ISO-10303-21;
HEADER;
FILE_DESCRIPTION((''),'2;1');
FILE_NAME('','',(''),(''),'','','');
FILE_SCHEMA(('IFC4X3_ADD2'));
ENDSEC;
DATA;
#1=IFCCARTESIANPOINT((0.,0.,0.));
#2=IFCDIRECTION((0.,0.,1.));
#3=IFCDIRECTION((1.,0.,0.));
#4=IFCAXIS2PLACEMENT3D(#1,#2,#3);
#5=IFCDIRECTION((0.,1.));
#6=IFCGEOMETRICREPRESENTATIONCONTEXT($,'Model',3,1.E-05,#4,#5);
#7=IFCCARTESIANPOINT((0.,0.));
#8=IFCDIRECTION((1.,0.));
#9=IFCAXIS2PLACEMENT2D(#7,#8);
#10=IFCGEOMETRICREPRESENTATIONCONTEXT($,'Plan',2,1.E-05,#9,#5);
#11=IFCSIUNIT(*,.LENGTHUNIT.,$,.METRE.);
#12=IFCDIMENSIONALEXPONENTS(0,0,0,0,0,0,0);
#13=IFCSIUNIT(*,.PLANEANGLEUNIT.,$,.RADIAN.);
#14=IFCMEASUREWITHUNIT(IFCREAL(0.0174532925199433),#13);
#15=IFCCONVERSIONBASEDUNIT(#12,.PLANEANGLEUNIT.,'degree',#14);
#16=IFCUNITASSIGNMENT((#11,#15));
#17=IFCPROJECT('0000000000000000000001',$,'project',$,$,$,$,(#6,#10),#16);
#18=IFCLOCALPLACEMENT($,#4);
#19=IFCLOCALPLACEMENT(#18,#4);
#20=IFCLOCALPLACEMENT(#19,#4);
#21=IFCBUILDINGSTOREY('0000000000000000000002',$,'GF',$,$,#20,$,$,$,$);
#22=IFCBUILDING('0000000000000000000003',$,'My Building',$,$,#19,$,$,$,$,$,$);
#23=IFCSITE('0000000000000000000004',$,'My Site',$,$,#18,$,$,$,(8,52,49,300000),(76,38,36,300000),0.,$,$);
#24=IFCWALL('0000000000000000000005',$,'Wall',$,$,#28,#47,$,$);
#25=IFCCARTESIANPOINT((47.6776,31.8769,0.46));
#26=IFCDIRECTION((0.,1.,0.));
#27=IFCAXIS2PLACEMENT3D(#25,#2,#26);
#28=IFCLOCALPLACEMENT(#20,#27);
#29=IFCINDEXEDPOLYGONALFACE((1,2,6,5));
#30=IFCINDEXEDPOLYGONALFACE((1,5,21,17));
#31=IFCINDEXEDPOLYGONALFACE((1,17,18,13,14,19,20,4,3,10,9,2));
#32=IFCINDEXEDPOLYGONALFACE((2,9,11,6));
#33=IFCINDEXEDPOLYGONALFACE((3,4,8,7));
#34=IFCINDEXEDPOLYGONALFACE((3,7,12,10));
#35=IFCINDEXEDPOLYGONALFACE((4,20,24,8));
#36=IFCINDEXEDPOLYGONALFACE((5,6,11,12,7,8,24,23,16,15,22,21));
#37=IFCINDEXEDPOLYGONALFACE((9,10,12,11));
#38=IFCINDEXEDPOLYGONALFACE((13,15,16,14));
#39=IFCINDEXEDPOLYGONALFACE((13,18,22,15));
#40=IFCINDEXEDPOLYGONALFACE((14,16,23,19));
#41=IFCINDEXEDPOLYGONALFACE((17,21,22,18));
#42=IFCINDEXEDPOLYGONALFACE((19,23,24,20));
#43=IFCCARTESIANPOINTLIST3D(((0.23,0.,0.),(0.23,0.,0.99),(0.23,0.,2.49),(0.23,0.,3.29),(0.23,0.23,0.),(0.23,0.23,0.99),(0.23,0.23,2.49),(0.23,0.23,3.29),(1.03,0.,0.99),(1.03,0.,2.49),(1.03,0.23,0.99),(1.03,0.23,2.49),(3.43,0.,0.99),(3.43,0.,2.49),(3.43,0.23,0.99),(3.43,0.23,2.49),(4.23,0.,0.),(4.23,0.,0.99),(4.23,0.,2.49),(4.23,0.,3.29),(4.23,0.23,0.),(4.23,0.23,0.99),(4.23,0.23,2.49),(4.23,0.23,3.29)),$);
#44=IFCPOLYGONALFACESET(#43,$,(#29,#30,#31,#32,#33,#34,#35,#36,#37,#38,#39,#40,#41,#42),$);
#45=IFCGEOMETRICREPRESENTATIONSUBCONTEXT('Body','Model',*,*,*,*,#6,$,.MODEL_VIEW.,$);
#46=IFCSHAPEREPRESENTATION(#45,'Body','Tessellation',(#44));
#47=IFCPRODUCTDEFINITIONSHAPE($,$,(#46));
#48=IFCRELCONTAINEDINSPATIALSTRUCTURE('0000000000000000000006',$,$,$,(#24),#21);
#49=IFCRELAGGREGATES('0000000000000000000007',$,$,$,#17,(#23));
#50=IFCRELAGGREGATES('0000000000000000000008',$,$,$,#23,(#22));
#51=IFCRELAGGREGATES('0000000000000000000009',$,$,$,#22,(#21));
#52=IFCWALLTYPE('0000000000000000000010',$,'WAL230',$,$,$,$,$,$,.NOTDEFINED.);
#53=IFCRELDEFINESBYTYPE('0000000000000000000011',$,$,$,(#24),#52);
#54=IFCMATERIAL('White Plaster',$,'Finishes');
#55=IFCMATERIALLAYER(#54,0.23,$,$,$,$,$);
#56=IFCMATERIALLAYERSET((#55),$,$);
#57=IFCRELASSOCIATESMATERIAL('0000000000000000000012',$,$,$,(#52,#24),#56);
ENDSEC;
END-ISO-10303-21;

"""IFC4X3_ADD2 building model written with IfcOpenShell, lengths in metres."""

from ifc_helpers import new_model, entity, si_unit, converted_unit, direction, frame, origin_with_axes, origin_2d_with_axis, place, context, subcontext, project, spatial, line, indexed_curve, outline, extrude, source, transform, mapped, material, layer, layer_set, layer_usage, type_object, element, save


model = new_model("IFC4X3_ADD2")

# Units and contexts
model_context = context("Model", 3, precision=1e-05, world=origin_with_axes(), true_north=direction((0.0, 1.0)))
plan_context = context("Plan", 2, precision=1e-05, world=origin_2d_with_axis(), true_north=direction((0.0, 1.0)))
body_context_1 = subcontext(model_context, "Body", "Model", "MODEL_VIEW")
ifc_project = project(units=[si_unit("LENGTHUNIT", "METRE"), converted_unit("PLANEANGLEUNIT", "degree", entity("IfcReal", 0.0174532925199433), si_unit("PLANEANGLEUNIT", "RADIAN"), dimensions=[0, 0, 0, 0, 0, 0, 0])], contexts=[model_context, plan_context])

# Site, building, storey
site_placement = place(None, origin_with_axes())
site = spatial("IfcSite", under=ifc_project, at=site_placement, Name="My Site", RefLatitude=(8, 52, 49, 300000), RefLongitude=(76, 38, 36, 300000), RefElevation=0.0)
building_placement = place(site_placement, origin_with_axes())
building = spatial("IfcBuilding", under=site, at=building_placement, Name="My Building")
storey_placement = place(building_placement, origin_with_axes())
storey = spatial("IfcBuildingStorey", under=building, at=storey_placement, Name="GF")

# Wall, openings
ifc_material_1 = material(Name="White Plaster", Category="Finishes")
ifc_layer_1 = layer(ifc_material_1, 0.23)
ifc_layer_set_1 = layer_set([ifc_layer_1])
ifc_layer_usage_1 = layer_usage(ifc_layer_set_1, "AXIS2", "POSITIVE", 0.0)
wall_type = type_object("IfcWallType", Name="WAL230", PredefinedType="NOTDEFINED", material=ifc_layer_set_1)
wall_1_placement = place(storey_placement, frame((47.6776, 31.8769, 0.46), z_axis=(0.0, 0.0, 1.0), x_axis=(0.0, 1.0, 0.0)))
wall_1 = element("IfcWall", 1, at=wall_1_placement, inside=storey, type_object=wall_type, material=ifc_layer_usage_1, Name="Wall", context=body_context_1, shape_type="SweptSolid", body=[
    extrude(outline(indexed_curve([(0.23, 0.0), (0.23, 0.23), (4.23, 0.23), (4.23, 0.0)], segments=[line(1, 2, 3, 4, 1)])), origin_with_axes(), (0.0, 0.0, 1.0), 3.29),
])
shared_shape_1 = source(origin_with_axes(), body_context_1, "Body", "SweptSolid", [
    extrude(outline(indexed_curve([(0.0, 0.0), (0.8, 0.0), (0.8, 1.5), (0.0, 1.5)], segments=[line(1, 2, 3, 4, 1)])), frame((0.0, -0.6, 0.0), z_axis=(0.0, -1.0, 0.0), x_axis=(1.0, 0.0, 0.0)), (0.0, 0.0, -1.0), 1.2),
])
opening_1_placement = place(wall_1_placement, frame((1.03, 0.23, 0.99), z_axis=(0.0, 0.0, 1.0), x_axis=(-1.0, 0.0, 0.0)))
element("IfcOpeningElement", 2, at=opening_1_placement, cuts=wall_1, PredefinedType="OPENING", context=body_context_1, shape_type="MappedRepresentation", body=[
    mapped(shared_shape_1, transform((0.0, 0.0, 0.0), x_axis=(1.0, 0.0, 0.0), y_axis=(0.0, 1.0, 0.0), z_axis=(0.0, 0.0, 1.0), scale=1.0)),
])
opening_2_placement = place(wall_1_placement, frame((4.23, 0.23, 0.99), z_axis=(0.0, 0.0, 1.0), x_axis=(-1.0, 0.0, 0.0)))
element("IfcOpeningElement", 3, at=opening_2_placement, cuts=wall_1, PredefinedType="OPENING", context=body_context_1, shape_type="MappedRepresentation", body=[
    mapped(shared_shape_1, transform((0.0, 0.0, 0.0), x_axis=(1.0, 0.0, 0.0), y_axis=(0.0, 1.0, 0.0), z_axis=(0.0, 0.0, 1.0), scale=1.0)),
])

save(model, "model.ifc")
